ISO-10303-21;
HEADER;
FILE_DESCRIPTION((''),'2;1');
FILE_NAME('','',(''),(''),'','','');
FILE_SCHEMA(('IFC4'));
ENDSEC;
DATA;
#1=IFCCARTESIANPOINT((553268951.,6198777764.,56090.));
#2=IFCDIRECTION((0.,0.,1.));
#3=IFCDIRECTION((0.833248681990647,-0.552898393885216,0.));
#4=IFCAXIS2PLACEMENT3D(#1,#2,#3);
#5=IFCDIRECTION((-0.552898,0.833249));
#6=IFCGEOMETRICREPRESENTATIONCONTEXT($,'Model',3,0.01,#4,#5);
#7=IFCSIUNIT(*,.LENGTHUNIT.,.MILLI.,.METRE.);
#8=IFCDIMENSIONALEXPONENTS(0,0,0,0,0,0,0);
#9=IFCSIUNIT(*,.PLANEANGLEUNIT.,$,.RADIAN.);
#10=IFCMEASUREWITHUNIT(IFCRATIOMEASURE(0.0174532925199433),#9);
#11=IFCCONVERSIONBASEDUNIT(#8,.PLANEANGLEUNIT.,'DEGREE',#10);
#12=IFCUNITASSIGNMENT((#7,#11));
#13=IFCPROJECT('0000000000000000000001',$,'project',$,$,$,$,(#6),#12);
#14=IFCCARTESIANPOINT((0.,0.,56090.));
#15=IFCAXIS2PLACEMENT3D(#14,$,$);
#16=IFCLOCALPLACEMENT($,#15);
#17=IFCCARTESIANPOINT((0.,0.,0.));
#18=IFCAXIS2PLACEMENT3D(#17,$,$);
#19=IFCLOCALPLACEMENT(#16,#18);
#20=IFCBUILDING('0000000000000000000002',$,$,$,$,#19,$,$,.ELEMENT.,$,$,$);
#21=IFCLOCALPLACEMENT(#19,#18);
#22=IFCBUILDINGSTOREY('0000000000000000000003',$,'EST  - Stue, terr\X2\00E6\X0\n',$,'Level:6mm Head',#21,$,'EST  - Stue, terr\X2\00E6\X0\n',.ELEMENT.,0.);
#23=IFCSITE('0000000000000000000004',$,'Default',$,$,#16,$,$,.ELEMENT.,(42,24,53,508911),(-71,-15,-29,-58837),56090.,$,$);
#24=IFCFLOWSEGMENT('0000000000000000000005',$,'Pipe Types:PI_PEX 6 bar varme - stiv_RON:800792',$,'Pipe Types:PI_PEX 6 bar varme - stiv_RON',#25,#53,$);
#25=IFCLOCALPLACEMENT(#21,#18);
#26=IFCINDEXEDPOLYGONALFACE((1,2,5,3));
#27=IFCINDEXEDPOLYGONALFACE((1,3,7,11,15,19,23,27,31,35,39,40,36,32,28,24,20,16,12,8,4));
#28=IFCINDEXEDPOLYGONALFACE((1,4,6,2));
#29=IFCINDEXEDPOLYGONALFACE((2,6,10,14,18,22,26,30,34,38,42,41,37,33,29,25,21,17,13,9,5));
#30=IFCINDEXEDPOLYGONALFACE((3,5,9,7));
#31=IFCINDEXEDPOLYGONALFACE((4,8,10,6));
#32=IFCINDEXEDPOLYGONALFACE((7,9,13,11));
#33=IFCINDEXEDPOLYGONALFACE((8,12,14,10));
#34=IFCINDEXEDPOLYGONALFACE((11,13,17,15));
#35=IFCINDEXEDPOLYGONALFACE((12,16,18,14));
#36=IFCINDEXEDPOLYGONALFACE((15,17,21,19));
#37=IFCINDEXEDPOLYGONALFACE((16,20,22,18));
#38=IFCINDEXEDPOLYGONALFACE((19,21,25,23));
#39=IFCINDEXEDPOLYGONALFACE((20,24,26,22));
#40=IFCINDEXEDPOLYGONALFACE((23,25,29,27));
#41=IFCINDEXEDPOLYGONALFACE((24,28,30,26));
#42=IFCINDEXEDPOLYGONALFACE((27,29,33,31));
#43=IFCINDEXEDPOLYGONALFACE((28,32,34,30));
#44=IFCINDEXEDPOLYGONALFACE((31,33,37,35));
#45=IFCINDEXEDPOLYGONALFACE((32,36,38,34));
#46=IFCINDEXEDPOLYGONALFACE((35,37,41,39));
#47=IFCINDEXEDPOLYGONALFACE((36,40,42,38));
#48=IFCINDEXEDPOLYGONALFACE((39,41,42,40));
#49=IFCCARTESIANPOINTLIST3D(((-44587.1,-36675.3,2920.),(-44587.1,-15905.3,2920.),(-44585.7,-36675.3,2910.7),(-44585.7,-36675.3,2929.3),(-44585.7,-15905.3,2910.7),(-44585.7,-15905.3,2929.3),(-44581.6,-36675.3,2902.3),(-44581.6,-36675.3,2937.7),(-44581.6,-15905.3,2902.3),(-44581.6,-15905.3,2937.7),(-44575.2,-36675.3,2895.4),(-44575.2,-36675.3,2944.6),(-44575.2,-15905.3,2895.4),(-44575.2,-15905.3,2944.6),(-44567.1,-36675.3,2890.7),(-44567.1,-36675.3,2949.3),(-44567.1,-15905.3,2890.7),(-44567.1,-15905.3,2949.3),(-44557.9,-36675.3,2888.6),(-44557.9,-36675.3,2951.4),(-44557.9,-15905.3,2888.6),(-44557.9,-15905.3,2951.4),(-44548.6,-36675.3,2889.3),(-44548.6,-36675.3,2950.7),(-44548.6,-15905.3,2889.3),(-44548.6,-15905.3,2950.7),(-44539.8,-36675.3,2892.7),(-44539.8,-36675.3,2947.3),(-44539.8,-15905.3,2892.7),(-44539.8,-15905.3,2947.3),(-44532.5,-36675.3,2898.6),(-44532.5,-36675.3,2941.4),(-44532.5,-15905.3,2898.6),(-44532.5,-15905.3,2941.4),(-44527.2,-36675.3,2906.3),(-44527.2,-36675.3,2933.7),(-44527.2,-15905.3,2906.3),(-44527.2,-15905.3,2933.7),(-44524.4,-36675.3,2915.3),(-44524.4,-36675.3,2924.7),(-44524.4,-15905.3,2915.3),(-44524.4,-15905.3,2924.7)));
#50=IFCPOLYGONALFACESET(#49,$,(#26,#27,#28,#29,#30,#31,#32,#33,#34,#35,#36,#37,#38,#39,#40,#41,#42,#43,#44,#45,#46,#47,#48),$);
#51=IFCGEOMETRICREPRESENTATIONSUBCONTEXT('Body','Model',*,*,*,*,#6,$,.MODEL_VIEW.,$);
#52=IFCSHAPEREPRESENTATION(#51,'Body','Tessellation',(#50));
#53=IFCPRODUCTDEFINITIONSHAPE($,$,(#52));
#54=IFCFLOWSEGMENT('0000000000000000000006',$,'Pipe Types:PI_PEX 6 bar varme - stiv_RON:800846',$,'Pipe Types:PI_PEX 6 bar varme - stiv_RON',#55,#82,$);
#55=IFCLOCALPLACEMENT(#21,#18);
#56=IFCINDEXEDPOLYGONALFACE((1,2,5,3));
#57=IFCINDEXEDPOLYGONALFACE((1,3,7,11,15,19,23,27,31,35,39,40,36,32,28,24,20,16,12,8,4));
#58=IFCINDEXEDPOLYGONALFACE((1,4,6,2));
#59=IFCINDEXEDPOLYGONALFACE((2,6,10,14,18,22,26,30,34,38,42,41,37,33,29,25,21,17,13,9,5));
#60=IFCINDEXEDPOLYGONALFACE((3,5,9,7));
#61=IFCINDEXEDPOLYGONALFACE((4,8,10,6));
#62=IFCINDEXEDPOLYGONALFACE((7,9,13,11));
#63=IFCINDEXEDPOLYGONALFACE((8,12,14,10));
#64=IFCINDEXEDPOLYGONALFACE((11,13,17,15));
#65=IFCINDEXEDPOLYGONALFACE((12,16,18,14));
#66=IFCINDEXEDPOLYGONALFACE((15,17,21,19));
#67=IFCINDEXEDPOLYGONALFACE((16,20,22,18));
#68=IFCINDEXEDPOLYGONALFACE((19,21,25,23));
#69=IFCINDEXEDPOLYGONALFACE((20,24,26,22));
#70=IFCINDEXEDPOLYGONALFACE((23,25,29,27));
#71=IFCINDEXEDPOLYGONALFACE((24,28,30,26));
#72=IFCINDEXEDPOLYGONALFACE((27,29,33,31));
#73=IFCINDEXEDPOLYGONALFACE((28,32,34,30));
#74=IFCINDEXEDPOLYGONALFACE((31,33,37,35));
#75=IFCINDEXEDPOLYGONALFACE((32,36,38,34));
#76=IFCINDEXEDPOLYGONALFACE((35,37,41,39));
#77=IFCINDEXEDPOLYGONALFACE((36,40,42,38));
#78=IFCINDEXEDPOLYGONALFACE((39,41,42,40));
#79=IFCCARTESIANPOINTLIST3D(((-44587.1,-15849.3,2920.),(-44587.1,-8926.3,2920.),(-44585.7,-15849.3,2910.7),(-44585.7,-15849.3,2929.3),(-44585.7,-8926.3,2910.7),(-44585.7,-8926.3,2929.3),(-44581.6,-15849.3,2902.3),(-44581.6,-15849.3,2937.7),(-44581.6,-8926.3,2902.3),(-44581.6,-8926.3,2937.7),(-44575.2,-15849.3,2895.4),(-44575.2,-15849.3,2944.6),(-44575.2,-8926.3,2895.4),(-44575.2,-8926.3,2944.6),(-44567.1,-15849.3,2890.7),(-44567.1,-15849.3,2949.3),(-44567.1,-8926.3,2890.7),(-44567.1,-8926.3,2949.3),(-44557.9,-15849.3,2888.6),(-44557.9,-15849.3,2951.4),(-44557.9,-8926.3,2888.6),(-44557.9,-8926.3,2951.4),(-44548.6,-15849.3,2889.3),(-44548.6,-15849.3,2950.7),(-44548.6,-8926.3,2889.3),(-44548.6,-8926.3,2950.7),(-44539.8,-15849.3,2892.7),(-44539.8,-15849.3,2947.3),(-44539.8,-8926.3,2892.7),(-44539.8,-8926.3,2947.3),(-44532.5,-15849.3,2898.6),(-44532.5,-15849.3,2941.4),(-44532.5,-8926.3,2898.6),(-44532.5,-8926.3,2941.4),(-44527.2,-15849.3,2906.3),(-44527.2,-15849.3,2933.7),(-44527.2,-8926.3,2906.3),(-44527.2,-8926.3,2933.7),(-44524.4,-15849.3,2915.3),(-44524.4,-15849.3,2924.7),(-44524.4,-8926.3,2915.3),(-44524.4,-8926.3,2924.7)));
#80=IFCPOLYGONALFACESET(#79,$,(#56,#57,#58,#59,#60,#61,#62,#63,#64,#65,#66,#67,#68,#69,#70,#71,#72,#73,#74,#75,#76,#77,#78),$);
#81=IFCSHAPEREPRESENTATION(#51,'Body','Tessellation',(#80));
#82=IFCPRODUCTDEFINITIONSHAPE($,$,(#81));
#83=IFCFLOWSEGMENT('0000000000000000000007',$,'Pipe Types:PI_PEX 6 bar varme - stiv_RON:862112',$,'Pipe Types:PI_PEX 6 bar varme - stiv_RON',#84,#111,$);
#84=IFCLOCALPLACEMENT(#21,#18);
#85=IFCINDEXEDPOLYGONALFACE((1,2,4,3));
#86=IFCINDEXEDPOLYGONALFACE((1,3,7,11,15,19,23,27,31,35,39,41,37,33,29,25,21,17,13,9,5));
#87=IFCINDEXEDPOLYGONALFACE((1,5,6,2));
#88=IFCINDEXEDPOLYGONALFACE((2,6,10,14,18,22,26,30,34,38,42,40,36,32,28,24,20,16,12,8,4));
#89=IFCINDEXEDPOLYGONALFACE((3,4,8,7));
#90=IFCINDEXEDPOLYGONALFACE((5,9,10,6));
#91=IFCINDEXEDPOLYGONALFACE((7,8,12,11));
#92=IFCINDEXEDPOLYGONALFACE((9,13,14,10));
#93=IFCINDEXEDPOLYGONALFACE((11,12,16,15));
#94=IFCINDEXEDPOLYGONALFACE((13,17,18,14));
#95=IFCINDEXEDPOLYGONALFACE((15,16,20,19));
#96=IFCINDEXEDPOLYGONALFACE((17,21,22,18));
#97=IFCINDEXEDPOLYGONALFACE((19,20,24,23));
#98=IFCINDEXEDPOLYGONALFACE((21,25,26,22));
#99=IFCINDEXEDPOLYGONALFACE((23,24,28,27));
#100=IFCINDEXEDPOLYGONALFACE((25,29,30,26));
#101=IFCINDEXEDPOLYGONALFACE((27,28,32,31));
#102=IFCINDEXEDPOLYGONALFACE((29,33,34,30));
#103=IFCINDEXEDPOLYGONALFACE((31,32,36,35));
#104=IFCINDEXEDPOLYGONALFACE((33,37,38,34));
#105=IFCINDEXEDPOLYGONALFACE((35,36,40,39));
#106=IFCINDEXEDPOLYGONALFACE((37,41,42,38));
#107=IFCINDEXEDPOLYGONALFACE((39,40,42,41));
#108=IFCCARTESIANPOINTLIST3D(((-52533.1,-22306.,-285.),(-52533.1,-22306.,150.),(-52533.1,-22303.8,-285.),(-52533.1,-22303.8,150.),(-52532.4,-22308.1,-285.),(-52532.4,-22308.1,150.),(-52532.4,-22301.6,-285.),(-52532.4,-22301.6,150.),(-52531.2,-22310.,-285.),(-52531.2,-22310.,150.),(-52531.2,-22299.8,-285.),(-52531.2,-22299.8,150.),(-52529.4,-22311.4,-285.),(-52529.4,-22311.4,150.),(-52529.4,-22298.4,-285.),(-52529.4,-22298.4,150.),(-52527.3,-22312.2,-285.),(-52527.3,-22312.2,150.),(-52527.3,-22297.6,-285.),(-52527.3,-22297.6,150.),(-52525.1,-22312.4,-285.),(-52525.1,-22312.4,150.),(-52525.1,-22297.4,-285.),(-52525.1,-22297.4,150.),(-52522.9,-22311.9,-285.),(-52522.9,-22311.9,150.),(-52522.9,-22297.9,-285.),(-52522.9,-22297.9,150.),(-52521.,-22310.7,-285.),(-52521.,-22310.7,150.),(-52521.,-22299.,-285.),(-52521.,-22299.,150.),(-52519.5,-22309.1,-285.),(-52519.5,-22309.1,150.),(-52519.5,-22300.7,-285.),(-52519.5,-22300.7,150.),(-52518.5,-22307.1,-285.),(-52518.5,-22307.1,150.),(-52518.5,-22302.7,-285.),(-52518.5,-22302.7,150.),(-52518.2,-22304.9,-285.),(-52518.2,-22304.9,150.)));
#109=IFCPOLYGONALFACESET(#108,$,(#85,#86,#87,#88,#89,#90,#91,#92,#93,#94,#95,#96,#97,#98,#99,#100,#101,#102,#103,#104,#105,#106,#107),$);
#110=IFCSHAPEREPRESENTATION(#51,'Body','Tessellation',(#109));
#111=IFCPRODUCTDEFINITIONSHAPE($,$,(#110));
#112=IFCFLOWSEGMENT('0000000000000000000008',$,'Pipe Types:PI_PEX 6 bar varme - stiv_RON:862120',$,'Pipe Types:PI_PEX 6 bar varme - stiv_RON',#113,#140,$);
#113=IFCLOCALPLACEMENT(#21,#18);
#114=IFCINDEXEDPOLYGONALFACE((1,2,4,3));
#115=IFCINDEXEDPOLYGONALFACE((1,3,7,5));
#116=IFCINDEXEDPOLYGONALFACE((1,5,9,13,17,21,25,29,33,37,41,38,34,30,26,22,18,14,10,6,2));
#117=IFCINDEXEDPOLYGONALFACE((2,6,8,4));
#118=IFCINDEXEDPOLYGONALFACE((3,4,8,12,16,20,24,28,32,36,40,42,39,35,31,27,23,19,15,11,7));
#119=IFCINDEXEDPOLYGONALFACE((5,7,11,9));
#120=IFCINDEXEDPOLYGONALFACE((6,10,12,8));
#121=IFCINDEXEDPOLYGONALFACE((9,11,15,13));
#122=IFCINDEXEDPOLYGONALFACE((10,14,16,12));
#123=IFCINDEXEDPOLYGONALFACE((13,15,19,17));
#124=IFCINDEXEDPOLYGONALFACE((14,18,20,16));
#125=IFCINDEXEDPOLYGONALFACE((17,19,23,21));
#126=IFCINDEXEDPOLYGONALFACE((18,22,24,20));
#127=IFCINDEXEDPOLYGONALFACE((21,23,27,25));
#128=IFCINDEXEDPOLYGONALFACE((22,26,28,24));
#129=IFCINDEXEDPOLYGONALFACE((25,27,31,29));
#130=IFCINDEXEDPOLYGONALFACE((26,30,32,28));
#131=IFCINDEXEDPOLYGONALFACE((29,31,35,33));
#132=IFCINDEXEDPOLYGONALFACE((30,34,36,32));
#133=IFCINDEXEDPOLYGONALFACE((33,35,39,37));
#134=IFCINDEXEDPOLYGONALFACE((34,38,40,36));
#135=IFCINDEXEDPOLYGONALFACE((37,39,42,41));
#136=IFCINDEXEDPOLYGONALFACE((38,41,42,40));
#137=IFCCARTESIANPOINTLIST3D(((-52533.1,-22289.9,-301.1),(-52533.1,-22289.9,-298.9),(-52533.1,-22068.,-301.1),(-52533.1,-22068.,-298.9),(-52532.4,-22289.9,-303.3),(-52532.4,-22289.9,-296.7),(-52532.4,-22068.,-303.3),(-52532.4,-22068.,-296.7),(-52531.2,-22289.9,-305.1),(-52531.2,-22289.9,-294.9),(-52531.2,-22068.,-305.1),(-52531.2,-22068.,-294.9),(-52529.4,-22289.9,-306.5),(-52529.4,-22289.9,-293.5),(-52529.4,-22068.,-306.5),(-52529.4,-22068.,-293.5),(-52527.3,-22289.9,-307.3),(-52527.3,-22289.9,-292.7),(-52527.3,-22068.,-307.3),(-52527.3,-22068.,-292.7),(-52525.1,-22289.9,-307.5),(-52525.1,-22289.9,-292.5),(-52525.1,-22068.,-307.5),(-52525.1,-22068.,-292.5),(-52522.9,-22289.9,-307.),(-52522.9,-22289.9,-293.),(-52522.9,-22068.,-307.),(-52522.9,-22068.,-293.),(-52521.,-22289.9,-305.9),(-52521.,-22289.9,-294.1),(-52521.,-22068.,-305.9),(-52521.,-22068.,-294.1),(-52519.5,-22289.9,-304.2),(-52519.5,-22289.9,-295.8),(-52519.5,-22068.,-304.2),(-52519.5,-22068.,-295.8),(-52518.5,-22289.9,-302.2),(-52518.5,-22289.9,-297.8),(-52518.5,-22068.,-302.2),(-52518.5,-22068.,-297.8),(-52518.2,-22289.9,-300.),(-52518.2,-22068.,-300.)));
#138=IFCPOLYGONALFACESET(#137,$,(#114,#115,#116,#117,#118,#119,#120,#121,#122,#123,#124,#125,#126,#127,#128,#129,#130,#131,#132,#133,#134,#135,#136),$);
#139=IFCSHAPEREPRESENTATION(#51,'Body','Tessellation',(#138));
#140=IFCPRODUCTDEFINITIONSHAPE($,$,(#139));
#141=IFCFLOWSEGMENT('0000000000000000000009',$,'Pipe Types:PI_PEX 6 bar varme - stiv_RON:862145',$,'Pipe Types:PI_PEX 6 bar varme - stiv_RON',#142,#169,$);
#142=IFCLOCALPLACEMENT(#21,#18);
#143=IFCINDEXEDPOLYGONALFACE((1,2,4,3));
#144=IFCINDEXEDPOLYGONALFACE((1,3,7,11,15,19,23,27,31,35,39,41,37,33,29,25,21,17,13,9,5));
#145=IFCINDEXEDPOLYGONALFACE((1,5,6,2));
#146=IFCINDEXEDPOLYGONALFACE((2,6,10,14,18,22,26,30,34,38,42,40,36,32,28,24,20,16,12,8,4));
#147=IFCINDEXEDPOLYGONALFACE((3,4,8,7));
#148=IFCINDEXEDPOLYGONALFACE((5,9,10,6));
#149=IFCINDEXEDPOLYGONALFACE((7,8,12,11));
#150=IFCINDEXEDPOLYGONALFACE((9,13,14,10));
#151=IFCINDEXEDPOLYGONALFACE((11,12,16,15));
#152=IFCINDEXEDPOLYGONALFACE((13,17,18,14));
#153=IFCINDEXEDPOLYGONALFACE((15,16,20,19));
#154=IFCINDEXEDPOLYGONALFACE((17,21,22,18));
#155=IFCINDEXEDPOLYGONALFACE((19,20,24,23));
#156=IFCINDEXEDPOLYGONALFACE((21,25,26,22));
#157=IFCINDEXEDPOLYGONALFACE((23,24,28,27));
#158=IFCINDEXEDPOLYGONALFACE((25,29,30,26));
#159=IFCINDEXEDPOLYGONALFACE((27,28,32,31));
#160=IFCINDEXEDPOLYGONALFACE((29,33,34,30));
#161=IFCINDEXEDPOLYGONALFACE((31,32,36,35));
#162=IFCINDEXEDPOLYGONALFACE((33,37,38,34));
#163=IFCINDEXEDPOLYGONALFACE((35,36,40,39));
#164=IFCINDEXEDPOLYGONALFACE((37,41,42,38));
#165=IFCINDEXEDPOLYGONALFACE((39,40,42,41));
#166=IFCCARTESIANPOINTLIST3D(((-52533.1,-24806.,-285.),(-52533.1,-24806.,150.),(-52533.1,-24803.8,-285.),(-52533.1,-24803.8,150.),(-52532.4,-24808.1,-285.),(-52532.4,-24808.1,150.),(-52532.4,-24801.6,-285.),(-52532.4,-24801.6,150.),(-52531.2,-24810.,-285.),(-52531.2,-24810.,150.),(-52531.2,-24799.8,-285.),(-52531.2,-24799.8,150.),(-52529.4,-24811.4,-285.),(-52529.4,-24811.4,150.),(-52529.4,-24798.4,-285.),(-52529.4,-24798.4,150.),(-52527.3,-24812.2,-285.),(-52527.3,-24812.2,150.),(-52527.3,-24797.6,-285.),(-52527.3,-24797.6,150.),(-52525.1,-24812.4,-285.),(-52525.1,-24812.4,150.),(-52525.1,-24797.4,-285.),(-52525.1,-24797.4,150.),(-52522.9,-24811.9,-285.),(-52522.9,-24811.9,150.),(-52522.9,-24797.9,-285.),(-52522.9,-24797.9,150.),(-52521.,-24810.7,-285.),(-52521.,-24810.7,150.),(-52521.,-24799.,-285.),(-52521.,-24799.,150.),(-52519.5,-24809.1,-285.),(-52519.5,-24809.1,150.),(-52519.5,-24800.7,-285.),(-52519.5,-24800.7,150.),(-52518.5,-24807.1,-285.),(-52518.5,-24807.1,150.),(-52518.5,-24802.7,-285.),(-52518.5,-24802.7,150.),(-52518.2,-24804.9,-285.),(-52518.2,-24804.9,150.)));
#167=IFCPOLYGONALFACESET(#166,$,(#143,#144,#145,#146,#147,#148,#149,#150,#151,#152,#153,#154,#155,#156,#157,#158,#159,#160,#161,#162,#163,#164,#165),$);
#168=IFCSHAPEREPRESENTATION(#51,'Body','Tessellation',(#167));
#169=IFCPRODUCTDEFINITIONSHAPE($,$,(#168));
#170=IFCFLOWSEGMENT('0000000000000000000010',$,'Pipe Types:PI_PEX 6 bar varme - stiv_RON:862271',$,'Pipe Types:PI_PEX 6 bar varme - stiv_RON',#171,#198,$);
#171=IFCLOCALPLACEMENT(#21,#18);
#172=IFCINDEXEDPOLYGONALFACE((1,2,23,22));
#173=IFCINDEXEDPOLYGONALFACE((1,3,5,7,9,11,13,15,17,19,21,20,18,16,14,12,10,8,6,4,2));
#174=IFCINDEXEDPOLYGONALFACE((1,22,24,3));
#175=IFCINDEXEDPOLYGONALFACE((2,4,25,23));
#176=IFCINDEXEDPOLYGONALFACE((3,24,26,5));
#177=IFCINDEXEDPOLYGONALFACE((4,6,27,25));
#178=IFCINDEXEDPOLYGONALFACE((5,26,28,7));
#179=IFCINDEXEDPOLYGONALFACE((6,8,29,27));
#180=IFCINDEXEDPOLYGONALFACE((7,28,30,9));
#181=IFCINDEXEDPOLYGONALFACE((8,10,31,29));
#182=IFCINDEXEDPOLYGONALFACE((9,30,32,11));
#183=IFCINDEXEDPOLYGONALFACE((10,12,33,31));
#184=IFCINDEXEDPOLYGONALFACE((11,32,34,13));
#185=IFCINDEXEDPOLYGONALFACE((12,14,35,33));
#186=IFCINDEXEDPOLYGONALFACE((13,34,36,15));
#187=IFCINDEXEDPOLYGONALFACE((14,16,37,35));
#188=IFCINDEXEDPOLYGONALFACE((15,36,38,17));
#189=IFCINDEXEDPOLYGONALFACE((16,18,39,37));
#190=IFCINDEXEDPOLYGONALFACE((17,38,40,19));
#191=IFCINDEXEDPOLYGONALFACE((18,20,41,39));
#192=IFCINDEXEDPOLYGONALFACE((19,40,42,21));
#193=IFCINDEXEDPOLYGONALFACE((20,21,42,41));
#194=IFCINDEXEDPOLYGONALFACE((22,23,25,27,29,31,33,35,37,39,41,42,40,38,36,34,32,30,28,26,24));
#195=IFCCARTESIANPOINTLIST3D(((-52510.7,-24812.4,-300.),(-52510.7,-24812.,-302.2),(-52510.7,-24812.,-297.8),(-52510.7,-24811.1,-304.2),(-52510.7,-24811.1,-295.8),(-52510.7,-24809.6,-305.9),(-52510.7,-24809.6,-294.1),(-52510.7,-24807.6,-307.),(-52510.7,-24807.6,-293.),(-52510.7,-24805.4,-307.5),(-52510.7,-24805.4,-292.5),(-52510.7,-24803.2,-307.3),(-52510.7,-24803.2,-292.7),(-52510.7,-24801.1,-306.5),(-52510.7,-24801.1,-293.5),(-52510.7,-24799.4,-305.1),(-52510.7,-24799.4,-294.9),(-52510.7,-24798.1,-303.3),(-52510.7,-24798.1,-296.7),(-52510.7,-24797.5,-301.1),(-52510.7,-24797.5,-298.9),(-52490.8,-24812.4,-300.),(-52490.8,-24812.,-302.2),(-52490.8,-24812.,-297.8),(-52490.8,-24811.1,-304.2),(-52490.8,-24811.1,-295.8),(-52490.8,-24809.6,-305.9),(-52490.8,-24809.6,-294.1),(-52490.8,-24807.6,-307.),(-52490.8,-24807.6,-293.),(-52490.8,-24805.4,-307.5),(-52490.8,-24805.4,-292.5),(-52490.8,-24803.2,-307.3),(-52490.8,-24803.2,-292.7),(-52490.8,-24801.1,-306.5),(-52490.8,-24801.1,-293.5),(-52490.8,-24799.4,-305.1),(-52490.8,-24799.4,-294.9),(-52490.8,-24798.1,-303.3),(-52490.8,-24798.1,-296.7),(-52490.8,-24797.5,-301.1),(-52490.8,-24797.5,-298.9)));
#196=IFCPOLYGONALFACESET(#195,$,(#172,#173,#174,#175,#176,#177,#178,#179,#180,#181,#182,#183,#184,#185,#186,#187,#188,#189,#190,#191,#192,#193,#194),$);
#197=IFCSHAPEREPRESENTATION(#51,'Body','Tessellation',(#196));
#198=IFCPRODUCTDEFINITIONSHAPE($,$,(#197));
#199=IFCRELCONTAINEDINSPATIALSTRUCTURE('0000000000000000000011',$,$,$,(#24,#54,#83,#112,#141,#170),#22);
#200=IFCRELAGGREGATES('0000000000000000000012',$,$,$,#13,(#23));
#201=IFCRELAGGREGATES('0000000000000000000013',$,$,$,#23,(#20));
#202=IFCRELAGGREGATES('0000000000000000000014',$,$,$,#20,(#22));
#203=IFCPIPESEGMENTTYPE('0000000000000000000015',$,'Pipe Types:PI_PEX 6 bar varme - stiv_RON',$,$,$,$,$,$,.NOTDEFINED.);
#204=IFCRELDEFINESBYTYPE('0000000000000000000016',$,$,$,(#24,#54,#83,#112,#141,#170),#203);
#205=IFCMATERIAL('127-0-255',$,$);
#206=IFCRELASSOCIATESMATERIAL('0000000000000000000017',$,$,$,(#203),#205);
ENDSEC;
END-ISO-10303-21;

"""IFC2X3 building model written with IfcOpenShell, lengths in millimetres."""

from ifc_helpers import new_model, entity, si_unit, converted_unit, direction, frame, frame_2d, origin, origin_2d_with_axis, place, context, subcontext, project, spatial, circle, extrude, material, type_object, element, save


model = new_model("IFC2X3")

# Units and contexts
model_context = context("Model", 3, precision=0.01, world=frame((553268951.0, 6198777764.0, 56090.0), z_axis=(0.0, 0.0, 1.0), x_axis=(0.833248681990647, -0.552898393885216, 0.0)), true_north=direction((-0.552898, 0.833249)))
body_context = subcontext(model_context, "Body", "Model", "MODEL_VIEW")
ifc_project = project(units=[si_unit("LENGTHUNIT", "METRE", prefix="MILLI"), converted_unit("PLANEANGLEUNIT", "DEGREE", entity("IfcRatioMeasure", 0.0174532925199433), si_unit("PLANEANGLEUNIT", "RADIAN"), dimensions=[0, 0, 0, 0, 0, 0, 0])], contexts=[model_context])

# Site, building, storey
site_placement = place(None, frame((0.0, 0.0, 56090.0)))
site = spatial("IfcSite", under=ifc_project, at=site_placement, Name="Default", CompositionType="ELEMENT", RefLatitude=(42, 24, 53, 508911), RefLongitude=(-71, -15, -29, -58837), RefElevation=56090.0)
building_placement = place(site_placement, origin())
building = spatial("IfcBuilding", under=site, at=building_placement, CompositionType="ELEMENT")
storey_placement = place(building_placement, frame((0.0, 0.0, 0.0)))
storey = spatial("IfcBuildingStorey", under=building, at=storey_placement, Name="EST  - Stue, terræn", ObjectType="Level:6mm Head", LongName="EST  - Stue, terræn", CompositionType="ELEMENT", Elevation=0.0)

# Flow segments
ifc_material_1 = material(Name="127-0-255")
pipe_segment_type_1 = type_object("IfcPipeSegmentType", Name="Pipe Types:PI_PEX 6 bar varme - stiv_RON", PredefinedType="NOTDEFINED", material=ifc_material_1)
flow_segment_1_placement = place(storey_placement, origin())
element("IfcFlowSegment", 1, at=flow_segment_1_placement, inside=storey, type_object=pipe_segment_type_1, Name="Pipe Types:PI_PEX 6 bar varme - stiv_RON:800792", ObjectType="Pipe Types:PI_PEX 6 bar varme - stiv_RON", context=body_context, shape_type="SweptSolid", body=[
    extrude(circle(Radius=31.5, at=frame_2d((0.0, 0.0), x_axis=(1.0, 0.0))), frame((-44555.6, -36675.3, 2920.0), z_axis=(0.0, 1.0, 0.0), x_axis=(-1.0, 0.0, 0.0)), (0.0, 0.0, 1.0), 20770.0),
])
flow_segment_2_placement = place(storey_placement, origin())
element("IfcFlowSegment", 2, at=flow_segment_2_placement, inside=storey, type_object=pipe_segment_type_1, Name="Pipe Types:PI_PEX 6 bar varme - stiv_RON:800846", ObjectType="Pipe Types:PI_PEX 6 bar varme - stiv_RON", context=body_context, shape_type="SweptSolid", body=[
    extrude(circle(Radius=31.5, at=origin_2d_with_axis()), frame((-44555.6, -15849.3, 2920.0), z_axis=(0.0, 1.0, 0.0), x_axis=(-1.0, 0.0, 0.0)), (0.0, 0.0, 1.0), 6923.1),
])
flow_segment_3_placement = place(storey_placement, origin())
element("IfcFlowSegment", 3, at=flow_segment_3_placement, inside=storey, type_object=pipe_segment_type_1, Name="Pipe Types:PI_PEX 6 bar varme - stiv_RON:862112", ObjectType="Pipe Types:PI_PEX 6 bar varme - stiv_RON", context=body_context, shape_type="SweptSolid", body=[
    extrude(circle(Radius=7.5, at=origin_2d_with_axis()), frame((-52525.7, -22304.9, -285.0)), (0.0, 0.0, 1.0), 435.0),
])
flow_segment_4_placement = place(storey_placement, origin())
element("IfcFlowSegment", 4, at=flow_segment_4_placement, inside=storey, type_object=pipe_segment_type_1, Name="Pipe Types:PI_PEX 6 bar varme - stiv_RON:862120", ObjectType="Pipe Types:PI_PEX 6 bar varme - stiv_RON", context=body_context, shape_type="SweptSolid", body=[
    extrude(circle(Radius=7.5, at=origin_2d_with_axis()), frame((-52525.7, -22289.9, -300.0), z_axis=(0.0, 1.0, 0.0), x_axis=(1.0, 0.0, 0.0)), (0.0, 0.0, 1.0), 221.9),
])
flow_segment_5_placement = place(storey_placement, origin())
element("IfcFlowSegment", 5, at=flow_segment_5_placement, inside=storey, type_object=pipe_segment_type_1, Name="Pipe Types:PI_PEX 6 bar varme - stiv_RON:862145", ObjectType="Pipe Types:PI_PEX 6 bar varme - stiv_RON", context=body_context, shape_type="SweptSolid", body=[
    extrude(circle(Radius=7.5, at=origin_2d_with_axis()), frame((-52525.7, -24804.9, -285.0)), (0.0, 0.0, 1.0), 435.0),
])
flow_segment_6_placement = place(storey_placement, origin())
element("IfcFlowSegment", 6, at=flow_segment_6_placement, inside=storey, type_object=pipe_segment_type_1, Name="Pipe Types:PI_PEX 6 bar varme - stiv_RON:862271", ObjectType="Pipe Types:PI_PEX 6 bar varme - stiv_RON", context=body_context, shape_type="SweptSolid", body=[
    extrude(circle(Radius=7.5, at=origin_2d_with_axis()), frame((-52510.7, -24804.9, -300.0), z_axis=(1.0, 0.0, 0.0), x_axis=(0.0, -1.0, 0.0)), (0.0, 0.0, 1.0), 19.8),
])

save(model, "model.ifc")
